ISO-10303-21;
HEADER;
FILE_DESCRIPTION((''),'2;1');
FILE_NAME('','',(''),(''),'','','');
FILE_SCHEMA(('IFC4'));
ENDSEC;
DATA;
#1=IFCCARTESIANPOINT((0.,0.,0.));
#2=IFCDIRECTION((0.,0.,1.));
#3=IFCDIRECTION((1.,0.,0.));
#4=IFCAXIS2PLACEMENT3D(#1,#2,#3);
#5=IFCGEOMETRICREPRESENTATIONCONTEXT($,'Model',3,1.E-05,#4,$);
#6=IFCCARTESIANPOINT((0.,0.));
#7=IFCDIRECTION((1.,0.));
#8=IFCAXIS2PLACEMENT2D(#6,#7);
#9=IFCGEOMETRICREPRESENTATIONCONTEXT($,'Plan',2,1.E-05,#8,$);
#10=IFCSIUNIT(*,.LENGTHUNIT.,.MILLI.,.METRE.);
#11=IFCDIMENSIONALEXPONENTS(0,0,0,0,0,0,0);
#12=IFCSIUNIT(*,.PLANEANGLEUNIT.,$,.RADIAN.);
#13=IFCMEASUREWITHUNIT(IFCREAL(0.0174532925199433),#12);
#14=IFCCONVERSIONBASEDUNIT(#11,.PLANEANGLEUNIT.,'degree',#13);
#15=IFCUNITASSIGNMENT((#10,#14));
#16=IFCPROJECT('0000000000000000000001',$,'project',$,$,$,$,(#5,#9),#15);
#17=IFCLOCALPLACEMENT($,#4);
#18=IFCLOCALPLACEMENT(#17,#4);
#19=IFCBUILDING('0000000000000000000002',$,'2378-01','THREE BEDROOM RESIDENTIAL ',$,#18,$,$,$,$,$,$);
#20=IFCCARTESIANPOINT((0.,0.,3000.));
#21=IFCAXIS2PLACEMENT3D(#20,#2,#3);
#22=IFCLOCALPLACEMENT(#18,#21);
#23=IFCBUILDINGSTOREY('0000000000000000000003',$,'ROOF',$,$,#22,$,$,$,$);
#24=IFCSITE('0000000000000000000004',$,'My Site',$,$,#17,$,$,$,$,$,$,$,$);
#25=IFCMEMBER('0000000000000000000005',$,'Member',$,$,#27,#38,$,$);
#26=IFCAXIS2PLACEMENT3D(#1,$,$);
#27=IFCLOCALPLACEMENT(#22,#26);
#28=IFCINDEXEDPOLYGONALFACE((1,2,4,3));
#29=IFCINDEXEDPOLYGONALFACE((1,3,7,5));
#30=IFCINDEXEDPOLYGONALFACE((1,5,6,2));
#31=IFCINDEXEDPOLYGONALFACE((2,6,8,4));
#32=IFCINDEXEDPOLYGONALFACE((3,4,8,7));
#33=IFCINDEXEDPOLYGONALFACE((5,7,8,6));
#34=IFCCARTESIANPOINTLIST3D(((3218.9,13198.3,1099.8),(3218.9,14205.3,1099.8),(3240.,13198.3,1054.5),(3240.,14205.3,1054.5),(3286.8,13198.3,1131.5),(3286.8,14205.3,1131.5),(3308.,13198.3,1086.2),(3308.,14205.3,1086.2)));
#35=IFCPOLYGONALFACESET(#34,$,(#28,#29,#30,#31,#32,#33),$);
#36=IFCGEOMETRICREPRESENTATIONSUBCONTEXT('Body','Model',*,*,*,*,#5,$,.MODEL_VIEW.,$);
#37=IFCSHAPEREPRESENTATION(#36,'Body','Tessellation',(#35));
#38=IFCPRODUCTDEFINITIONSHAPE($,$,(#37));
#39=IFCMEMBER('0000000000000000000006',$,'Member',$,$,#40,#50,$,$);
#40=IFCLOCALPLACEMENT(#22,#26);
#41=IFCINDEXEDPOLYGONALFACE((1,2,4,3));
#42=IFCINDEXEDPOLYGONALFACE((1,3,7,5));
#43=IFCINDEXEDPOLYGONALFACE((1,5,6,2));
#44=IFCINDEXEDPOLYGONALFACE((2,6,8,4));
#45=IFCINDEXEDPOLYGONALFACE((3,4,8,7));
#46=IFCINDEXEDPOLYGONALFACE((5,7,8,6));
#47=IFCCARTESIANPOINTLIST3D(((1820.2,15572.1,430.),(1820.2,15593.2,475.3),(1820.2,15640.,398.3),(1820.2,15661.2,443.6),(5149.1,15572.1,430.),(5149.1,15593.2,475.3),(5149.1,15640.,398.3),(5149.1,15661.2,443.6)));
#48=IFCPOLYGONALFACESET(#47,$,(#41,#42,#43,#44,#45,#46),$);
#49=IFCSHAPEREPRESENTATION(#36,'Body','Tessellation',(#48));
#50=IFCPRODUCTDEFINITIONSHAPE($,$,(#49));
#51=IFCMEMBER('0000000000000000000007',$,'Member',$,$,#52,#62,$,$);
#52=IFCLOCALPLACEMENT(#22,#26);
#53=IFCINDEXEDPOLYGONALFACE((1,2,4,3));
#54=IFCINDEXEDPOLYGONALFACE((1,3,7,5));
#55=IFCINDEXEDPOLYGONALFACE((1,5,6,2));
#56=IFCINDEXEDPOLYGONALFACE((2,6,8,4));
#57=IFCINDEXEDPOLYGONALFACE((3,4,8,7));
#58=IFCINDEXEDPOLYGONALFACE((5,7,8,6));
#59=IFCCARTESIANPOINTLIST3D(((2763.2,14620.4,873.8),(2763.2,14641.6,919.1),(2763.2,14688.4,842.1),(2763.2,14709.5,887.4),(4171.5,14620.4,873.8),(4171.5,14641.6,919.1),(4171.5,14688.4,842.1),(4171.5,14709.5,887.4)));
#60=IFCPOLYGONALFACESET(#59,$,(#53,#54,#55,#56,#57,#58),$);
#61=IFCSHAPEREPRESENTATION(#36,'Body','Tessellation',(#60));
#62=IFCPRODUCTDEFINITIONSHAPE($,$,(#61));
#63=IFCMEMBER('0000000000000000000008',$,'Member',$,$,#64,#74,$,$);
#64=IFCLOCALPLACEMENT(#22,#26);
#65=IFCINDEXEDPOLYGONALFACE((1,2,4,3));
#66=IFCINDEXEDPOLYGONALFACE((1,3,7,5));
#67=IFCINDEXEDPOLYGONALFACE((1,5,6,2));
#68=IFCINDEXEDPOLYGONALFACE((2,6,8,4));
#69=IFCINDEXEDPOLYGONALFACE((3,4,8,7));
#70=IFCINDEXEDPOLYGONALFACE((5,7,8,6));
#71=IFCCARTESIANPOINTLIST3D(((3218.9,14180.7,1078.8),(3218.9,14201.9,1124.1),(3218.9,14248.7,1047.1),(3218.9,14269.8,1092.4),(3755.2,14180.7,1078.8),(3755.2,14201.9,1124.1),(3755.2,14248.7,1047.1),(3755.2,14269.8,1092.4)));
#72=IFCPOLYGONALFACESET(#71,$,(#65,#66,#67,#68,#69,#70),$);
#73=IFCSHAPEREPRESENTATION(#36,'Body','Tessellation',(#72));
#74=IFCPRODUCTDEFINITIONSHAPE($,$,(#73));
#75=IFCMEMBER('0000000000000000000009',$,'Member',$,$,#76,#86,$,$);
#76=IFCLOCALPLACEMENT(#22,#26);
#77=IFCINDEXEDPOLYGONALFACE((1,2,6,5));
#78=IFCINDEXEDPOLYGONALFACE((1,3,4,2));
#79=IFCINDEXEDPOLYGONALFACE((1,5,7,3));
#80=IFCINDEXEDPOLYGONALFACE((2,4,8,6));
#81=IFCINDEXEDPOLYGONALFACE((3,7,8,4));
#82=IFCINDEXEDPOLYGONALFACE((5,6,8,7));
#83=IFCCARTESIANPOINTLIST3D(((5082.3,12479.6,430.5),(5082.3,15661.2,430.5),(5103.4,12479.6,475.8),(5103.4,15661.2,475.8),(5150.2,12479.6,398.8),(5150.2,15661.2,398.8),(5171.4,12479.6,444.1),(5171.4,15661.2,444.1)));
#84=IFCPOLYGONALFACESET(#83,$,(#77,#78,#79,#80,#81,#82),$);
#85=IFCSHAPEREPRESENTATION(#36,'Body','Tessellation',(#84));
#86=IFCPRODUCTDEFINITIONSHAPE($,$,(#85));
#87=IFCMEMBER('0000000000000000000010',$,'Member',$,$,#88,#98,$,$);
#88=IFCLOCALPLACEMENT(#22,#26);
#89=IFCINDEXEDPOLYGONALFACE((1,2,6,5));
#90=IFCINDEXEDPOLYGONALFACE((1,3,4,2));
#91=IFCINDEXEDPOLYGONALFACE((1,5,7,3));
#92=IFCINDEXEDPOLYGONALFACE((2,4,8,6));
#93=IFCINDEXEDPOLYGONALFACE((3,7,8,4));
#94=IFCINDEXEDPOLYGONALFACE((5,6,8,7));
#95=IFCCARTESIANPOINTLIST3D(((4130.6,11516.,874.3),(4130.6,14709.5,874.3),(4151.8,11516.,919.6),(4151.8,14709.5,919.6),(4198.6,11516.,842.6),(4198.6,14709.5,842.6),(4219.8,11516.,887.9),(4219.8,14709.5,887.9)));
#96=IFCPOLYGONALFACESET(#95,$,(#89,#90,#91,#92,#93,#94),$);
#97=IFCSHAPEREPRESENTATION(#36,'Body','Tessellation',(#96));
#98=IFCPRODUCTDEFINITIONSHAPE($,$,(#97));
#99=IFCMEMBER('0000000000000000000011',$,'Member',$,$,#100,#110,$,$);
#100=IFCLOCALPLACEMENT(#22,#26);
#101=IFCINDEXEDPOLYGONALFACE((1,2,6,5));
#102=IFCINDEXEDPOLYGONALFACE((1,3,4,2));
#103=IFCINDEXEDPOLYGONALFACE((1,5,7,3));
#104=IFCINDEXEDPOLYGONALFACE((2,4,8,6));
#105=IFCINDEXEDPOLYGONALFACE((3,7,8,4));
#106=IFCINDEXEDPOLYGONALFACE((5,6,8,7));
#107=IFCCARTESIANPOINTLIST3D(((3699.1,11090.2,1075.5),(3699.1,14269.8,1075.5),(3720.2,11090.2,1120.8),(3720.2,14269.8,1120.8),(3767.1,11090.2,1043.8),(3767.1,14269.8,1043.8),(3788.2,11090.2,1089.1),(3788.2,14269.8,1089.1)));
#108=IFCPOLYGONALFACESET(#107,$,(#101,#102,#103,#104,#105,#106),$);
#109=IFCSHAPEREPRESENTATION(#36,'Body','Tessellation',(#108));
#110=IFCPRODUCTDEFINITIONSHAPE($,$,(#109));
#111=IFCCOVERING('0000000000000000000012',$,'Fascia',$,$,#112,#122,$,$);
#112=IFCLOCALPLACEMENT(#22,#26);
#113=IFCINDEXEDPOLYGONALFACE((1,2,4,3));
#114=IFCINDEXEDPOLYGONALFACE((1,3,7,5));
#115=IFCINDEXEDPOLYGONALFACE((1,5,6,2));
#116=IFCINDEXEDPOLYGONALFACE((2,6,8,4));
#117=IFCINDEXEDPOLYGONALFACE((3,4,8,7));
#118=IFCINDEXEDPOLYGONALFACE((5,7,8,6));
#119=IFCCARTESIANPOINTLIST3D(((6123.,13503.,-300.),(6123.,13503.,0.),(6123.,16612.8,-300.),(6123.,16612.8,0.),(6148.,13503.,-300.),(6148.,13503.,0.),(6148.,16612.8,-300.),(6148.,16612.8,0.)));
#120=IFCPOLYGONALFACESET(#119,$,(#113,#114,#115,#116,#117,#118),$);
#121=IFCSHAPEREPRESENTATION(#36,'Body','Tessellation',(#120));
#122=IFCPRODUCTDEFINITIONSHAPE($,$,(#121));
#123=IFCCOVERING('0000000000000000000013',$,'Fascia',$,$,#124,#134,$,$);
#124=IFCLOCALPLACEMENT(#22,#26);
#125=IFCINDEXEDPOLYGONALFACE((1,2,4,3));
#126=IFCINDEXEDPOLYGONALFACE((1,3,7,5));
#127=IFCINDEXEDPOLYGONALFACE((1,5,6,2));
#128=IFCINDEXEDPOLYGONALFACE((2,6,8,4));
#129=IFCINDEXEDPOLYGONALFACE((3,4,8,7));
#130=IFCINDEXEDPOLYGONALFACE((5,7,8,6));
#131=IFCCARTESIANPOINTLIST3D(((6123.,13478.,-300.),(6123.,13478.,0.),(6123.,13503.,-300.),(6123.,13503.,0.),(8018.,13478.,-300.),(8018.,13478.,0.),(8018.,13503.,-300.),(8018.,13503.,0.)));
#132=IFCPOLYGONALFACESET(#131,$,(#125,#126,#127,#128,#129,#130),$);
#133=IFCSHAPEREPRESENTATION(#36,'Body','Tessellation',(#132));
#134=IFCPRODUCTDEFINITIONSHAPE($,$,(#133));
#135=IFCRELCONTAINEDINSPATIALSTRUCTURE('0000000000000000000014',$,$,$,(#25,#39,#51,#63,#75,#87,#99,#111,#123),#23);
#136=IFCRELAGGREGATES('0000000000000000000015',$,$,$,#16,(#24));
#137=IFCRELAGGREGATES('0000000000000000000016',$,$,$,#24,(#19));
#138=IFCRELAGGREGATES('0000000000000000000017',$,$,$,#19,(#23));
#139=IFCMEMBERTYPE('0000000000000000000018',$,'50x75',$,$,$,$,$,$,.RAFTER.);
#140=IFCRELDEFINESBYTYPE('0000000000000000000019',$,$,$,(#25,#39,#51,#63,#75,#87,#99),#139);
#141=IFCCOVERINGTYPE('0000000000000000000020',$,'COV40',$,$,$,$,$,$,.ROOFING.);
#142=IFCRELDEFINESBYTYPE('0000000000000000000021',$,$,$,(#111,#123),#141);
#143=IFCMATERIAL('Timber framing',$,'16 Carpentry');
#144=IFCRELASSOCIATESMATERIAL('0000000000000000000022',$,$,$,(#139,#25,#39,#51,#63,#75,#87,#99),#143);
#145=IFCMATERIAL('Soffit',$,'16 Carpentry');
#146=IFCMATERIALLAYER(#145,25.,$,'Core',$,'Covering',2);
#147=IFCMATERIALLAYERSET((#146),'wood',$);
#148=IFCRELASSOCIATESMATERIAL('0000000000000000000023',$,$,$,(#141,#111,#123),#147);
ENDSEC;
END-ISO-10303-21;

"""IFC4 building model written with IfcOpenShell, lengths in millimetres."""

from ifc_helpers import new_model, entity, si_unit, converted_unit, frame, origin_with_axes, origin_2d_with_axis, place, context, subcontext, project, spatial, indexed_curve, rectangle, outline, extrude, material, layer, layer_set, layer_usage, material_profile, profile_set, profile_usage, type_object, element, save


model = new_model("IFC4")

# Units and contexts
model_context = context("Model", 3, precision=1e-05, world=origin_with_axes())
plan_context = context("Plan", 2, precision=1e-05, world=origin_2d_with_axis())
body_context = subcontext(model_context, "Body", "Model", "MODEL_VIEW")
ifc_project = project(units=[si_unit("LENGTHUNIT", "METRE", prefix="MILLI"), converted_unit("PLANEANGLEUNIT", "degree", entity("IfcReal", 0.0174532925199433), si_unit("PLANEANGLEUNIT", "RADIAN"), dimensions=[0, 0, 0, 0, 0, 0, 0])], contexts=[model_context, plan_context])

# Site, building, storey
site_placement = place(None, origin_with_axes())
site = spatial("IfcSite", under=ifc_project, at=site_placement, Name="My Site")
building_placement = place(site_placement, origin_with_axes())
building = spatial("IfcBuilding", under=site, at=building_placement, Name="2378-01", Description="THREE BEDROOM RESIDENTIAL ")
storey_placement = place(building_placement, frame((0.0, 0.0, 3000.0), z_axis=(0.0, 0.0, 1.0), x_axis=(1.0, 0.0, 0.0)))
storey = spatial("IfcBuildingStorey", under=building, at=storey_placement, Name="ROOF")

# Members
ifc_material_1 = material(Name="Timber framing", Category="16 Carpentry")
ifc_material_profile_1 = material_profile(ifc_material_1, rectangle(XDim=50.0, YDim=75.0), Name="Lumber2", Category="Substrate", Priority=2)
ifc_profile_set_1 = profile_set([ifc_material_profile_1])
member_type_1 = type_object("IfcMemberType", Name="50x75", PredefinedType="RAFTER", material=ifc_profile_set_1)
ifc_profile_usage_1 = profile_usage(ifc_profile_set_1, cardinal=5)
member_1_placement = place(storey_placement, frame((3263.4, 13198.3, 1093.0), z_axis=(0.0, 1.0, 0.0), x_axis=(-0.422618, 0.0, 0.906308)))
element("IfcMember", 1, at=member_1_placement, inside=storey, type_object=member_type_1, material=ifc_profile_usage_1, Name="Member", context=body_context, shape_type="SweptSolid", body=[
    extrude(rectangle(XDim=50.0, YDim=75.0), origin_with_axes(), (0.0, 0.0, 1.0), 1007.0),
])
ifc_profile_usage_2 = profile_usage(ifc_profile_set_1, cardinal=5)
member_2_placement = place(storey_placement, frame((5149.1, 15616.6, 436.8), z_axis=(-1.0, 0.0, 0.0), x_axis=(0.0, -0.422618, -0.906308)))
element("IfcMember", 2, at=member_2_placement, inside=storey, type_object=member_type_1, material=ifc_profile_usage_2, Name="Member", context=body_context, shape_type="SweptSolid", body=[
    extrude(rectangle(XDim=50.0, YDim=75.0), origin_with_axes(), (0.0, 0.0, 1.0), 3328.9),
])
ifc_profile_usage_3 = profile_usage(ifc_profile_set_1, cardinal=5)
member_3_placement = place(storey_placement, frame((4171.5, 14665.0, 880.6), z_axis=(-1.0, 0.0, 0.0), x_axis=(0.0, -0.422618, -0.906308)))
element("IfcMember", 3, at=member_3_placement, inside=storey, type_object=member_type_1, material=ifc_profile_usage_3, Name="Member", context=body_context, shape_type="SweptSolid", body=[
    extrude(rectangle(XDim=50.0, YDim=75.0), origin_with_axes(), (0.0, 0.0, 1.0), 1408.2),
])
ifc_profile_usage_4 = profile_usage(ifc_profile_set_1, cardinal=5)
member_4_placement = place(storey_placement, frame((3755.2, 14225.3, 1085.6), z_axis=(-1.0, 0.0, 0.0), x_axis=(0.0, -0.422618, -0.906308)))
element("IfcMember", 4, at=member_4_placement, inside=storey, type_object=member_type_1, material=ifc_profile_usage_4, Name="Member", context=body_context, shape_type="SweptSolid", body=[
    extrude(rectangle(XDim=50.0, YDim=75.0), origin_with_axes(), (0.0, 0.0, 1.0), 536.3),
])
ifc_profile_usage_5 = profile_usage(ifc_profile_set_1, cardinal=5)
member_5_placement = place(storey_placement, frame((5126.8, 12479.6, 437.3), z_axis=(0.0, 1.0, 0.0), x_axis=(-0.422618, 0.0, -0.906308)))
element("IfcMember", 5, at=member_5_placement, inside=storey, type_object=member_type_1, material=ifc_profile_usage_5, Name="Member", context=body_context, shape_type="SweptSolid", body=[
    extrude(rectangle(XDim=50.0, YDim=75.0), origin_with_axes(), (0.0, 0.0, 1.0), 3181.5),
])
ifc_profile_usage_6 = profile_usage(ifc_profile_set_1, cardinal=5)
member_6_placement = place(storey_placement, frame((4175.2, 11516.0, 881.1), z_axis=(0.0, 1.0, 0.0), x_axis=(-0.422618, 0.0, -0.906308)))
element("IfcMember", 6, at=member_6_placement, inside=storey, type_object=member_type_1, material=ifc_profile_usage_6, Name="Member", context=body_context, shape_type="SweptSolid", body=[
    extrude(rectangle(XDim=50.0, YDim=75.0), origin_with_axes(), (0.0, 0.0, 1.0), 3193.5),
])
ifc_profile_usage_7 = profile_usage(ifc_profile_set_1, cardinal=5)
member_7_placement = place(storey_placement, frame((3743.6, 11090.2, 1082.3), z_axis=(0.0, 1.0, 0.0), x_axis=(-0.422618, 0.0, -0.906308)))
element("IfcMember", 7, at=member_7_placement, inside=storey, type_object=member_type_1, material=ifc_profile_usage_7, Name="Member", context=body_context, shape_type="SweptSolid", body=[
    extrude(rectangle(XDim=50.0, YDim=75.0), origin_with_axes(), (0.0, 0.0, 1.0), 3179.7),
])

# Coverings
ifc_material_2 = material(Name="Soffit", Category="16 Carpentry")
ifc_layer_1 = layer(ifc_material_2, 25.0, Name="Core", Category="Covering", Priority=2)
ifc_layer_set_1 = layer_set([ifc_layer_1], Name="wood")
ifc_layer_usage_1 = layer_usage(ifc_layer_set_1, "AXIS2", "POSITIVE", 0.0)
covering_type_1 = type_object("IfcCoveringType", Name="COV40", PredefinedType="ROOFING", material=ifc_layer_set_1)
covering_1_placement = place(storey_placement, frame((6123.0, 16612.8, -300.0), z_axis=(0.0, 0.0, 1.0), x_axis=(0.0, -1.0, 0.0)))
element("IfcCovering", 8, at=covering_1_placement, inside=storey, type_object=covering_type_1, material=ifc_layer_usage_1, Name="Fascia", context=body_context, shape_type="SweptSolid", body=[
    extrude(outline(indexed_curve([(0.0, 0.0), (0.0, 25.0), (3109.8, 25.0), (3109.8, 0.0), (0.0, 0.0)], self_intersect=False)), origin_with_axes(), (0.0, 0.0, 1.0), 300.0),
])
ifc_layer_usage_2 = layer_usage(ifc_layer_set_1, "AXIS2", "POSITIVE", 0.0)
covering_2_placement = place(storey_placement, frame((6123.0, 13478.0, -300.0), z_axis=(0.0, 0.0, 1.0), x_axis=(1.0, 0.0, 0.0)))
element("IfcCovering", 9, at=covering_2_placement, inside=storey, type_object=covering_type_1, material=ifc_layer_usage_2, Name="Fascia", context=body_context, shape_type="SweptSolid", body=[
    extrude(outline(indexed_curve([(0.0, 0.0), (0.0, 25.0), (1895.0, 25.0), (1895.0, 0.0), (0.0, 0.0)], self_intersect=False)), origin_with_axes(), (0.0, 0.0, 1.0), 300.0),
])

save(model, "model.ifc")
